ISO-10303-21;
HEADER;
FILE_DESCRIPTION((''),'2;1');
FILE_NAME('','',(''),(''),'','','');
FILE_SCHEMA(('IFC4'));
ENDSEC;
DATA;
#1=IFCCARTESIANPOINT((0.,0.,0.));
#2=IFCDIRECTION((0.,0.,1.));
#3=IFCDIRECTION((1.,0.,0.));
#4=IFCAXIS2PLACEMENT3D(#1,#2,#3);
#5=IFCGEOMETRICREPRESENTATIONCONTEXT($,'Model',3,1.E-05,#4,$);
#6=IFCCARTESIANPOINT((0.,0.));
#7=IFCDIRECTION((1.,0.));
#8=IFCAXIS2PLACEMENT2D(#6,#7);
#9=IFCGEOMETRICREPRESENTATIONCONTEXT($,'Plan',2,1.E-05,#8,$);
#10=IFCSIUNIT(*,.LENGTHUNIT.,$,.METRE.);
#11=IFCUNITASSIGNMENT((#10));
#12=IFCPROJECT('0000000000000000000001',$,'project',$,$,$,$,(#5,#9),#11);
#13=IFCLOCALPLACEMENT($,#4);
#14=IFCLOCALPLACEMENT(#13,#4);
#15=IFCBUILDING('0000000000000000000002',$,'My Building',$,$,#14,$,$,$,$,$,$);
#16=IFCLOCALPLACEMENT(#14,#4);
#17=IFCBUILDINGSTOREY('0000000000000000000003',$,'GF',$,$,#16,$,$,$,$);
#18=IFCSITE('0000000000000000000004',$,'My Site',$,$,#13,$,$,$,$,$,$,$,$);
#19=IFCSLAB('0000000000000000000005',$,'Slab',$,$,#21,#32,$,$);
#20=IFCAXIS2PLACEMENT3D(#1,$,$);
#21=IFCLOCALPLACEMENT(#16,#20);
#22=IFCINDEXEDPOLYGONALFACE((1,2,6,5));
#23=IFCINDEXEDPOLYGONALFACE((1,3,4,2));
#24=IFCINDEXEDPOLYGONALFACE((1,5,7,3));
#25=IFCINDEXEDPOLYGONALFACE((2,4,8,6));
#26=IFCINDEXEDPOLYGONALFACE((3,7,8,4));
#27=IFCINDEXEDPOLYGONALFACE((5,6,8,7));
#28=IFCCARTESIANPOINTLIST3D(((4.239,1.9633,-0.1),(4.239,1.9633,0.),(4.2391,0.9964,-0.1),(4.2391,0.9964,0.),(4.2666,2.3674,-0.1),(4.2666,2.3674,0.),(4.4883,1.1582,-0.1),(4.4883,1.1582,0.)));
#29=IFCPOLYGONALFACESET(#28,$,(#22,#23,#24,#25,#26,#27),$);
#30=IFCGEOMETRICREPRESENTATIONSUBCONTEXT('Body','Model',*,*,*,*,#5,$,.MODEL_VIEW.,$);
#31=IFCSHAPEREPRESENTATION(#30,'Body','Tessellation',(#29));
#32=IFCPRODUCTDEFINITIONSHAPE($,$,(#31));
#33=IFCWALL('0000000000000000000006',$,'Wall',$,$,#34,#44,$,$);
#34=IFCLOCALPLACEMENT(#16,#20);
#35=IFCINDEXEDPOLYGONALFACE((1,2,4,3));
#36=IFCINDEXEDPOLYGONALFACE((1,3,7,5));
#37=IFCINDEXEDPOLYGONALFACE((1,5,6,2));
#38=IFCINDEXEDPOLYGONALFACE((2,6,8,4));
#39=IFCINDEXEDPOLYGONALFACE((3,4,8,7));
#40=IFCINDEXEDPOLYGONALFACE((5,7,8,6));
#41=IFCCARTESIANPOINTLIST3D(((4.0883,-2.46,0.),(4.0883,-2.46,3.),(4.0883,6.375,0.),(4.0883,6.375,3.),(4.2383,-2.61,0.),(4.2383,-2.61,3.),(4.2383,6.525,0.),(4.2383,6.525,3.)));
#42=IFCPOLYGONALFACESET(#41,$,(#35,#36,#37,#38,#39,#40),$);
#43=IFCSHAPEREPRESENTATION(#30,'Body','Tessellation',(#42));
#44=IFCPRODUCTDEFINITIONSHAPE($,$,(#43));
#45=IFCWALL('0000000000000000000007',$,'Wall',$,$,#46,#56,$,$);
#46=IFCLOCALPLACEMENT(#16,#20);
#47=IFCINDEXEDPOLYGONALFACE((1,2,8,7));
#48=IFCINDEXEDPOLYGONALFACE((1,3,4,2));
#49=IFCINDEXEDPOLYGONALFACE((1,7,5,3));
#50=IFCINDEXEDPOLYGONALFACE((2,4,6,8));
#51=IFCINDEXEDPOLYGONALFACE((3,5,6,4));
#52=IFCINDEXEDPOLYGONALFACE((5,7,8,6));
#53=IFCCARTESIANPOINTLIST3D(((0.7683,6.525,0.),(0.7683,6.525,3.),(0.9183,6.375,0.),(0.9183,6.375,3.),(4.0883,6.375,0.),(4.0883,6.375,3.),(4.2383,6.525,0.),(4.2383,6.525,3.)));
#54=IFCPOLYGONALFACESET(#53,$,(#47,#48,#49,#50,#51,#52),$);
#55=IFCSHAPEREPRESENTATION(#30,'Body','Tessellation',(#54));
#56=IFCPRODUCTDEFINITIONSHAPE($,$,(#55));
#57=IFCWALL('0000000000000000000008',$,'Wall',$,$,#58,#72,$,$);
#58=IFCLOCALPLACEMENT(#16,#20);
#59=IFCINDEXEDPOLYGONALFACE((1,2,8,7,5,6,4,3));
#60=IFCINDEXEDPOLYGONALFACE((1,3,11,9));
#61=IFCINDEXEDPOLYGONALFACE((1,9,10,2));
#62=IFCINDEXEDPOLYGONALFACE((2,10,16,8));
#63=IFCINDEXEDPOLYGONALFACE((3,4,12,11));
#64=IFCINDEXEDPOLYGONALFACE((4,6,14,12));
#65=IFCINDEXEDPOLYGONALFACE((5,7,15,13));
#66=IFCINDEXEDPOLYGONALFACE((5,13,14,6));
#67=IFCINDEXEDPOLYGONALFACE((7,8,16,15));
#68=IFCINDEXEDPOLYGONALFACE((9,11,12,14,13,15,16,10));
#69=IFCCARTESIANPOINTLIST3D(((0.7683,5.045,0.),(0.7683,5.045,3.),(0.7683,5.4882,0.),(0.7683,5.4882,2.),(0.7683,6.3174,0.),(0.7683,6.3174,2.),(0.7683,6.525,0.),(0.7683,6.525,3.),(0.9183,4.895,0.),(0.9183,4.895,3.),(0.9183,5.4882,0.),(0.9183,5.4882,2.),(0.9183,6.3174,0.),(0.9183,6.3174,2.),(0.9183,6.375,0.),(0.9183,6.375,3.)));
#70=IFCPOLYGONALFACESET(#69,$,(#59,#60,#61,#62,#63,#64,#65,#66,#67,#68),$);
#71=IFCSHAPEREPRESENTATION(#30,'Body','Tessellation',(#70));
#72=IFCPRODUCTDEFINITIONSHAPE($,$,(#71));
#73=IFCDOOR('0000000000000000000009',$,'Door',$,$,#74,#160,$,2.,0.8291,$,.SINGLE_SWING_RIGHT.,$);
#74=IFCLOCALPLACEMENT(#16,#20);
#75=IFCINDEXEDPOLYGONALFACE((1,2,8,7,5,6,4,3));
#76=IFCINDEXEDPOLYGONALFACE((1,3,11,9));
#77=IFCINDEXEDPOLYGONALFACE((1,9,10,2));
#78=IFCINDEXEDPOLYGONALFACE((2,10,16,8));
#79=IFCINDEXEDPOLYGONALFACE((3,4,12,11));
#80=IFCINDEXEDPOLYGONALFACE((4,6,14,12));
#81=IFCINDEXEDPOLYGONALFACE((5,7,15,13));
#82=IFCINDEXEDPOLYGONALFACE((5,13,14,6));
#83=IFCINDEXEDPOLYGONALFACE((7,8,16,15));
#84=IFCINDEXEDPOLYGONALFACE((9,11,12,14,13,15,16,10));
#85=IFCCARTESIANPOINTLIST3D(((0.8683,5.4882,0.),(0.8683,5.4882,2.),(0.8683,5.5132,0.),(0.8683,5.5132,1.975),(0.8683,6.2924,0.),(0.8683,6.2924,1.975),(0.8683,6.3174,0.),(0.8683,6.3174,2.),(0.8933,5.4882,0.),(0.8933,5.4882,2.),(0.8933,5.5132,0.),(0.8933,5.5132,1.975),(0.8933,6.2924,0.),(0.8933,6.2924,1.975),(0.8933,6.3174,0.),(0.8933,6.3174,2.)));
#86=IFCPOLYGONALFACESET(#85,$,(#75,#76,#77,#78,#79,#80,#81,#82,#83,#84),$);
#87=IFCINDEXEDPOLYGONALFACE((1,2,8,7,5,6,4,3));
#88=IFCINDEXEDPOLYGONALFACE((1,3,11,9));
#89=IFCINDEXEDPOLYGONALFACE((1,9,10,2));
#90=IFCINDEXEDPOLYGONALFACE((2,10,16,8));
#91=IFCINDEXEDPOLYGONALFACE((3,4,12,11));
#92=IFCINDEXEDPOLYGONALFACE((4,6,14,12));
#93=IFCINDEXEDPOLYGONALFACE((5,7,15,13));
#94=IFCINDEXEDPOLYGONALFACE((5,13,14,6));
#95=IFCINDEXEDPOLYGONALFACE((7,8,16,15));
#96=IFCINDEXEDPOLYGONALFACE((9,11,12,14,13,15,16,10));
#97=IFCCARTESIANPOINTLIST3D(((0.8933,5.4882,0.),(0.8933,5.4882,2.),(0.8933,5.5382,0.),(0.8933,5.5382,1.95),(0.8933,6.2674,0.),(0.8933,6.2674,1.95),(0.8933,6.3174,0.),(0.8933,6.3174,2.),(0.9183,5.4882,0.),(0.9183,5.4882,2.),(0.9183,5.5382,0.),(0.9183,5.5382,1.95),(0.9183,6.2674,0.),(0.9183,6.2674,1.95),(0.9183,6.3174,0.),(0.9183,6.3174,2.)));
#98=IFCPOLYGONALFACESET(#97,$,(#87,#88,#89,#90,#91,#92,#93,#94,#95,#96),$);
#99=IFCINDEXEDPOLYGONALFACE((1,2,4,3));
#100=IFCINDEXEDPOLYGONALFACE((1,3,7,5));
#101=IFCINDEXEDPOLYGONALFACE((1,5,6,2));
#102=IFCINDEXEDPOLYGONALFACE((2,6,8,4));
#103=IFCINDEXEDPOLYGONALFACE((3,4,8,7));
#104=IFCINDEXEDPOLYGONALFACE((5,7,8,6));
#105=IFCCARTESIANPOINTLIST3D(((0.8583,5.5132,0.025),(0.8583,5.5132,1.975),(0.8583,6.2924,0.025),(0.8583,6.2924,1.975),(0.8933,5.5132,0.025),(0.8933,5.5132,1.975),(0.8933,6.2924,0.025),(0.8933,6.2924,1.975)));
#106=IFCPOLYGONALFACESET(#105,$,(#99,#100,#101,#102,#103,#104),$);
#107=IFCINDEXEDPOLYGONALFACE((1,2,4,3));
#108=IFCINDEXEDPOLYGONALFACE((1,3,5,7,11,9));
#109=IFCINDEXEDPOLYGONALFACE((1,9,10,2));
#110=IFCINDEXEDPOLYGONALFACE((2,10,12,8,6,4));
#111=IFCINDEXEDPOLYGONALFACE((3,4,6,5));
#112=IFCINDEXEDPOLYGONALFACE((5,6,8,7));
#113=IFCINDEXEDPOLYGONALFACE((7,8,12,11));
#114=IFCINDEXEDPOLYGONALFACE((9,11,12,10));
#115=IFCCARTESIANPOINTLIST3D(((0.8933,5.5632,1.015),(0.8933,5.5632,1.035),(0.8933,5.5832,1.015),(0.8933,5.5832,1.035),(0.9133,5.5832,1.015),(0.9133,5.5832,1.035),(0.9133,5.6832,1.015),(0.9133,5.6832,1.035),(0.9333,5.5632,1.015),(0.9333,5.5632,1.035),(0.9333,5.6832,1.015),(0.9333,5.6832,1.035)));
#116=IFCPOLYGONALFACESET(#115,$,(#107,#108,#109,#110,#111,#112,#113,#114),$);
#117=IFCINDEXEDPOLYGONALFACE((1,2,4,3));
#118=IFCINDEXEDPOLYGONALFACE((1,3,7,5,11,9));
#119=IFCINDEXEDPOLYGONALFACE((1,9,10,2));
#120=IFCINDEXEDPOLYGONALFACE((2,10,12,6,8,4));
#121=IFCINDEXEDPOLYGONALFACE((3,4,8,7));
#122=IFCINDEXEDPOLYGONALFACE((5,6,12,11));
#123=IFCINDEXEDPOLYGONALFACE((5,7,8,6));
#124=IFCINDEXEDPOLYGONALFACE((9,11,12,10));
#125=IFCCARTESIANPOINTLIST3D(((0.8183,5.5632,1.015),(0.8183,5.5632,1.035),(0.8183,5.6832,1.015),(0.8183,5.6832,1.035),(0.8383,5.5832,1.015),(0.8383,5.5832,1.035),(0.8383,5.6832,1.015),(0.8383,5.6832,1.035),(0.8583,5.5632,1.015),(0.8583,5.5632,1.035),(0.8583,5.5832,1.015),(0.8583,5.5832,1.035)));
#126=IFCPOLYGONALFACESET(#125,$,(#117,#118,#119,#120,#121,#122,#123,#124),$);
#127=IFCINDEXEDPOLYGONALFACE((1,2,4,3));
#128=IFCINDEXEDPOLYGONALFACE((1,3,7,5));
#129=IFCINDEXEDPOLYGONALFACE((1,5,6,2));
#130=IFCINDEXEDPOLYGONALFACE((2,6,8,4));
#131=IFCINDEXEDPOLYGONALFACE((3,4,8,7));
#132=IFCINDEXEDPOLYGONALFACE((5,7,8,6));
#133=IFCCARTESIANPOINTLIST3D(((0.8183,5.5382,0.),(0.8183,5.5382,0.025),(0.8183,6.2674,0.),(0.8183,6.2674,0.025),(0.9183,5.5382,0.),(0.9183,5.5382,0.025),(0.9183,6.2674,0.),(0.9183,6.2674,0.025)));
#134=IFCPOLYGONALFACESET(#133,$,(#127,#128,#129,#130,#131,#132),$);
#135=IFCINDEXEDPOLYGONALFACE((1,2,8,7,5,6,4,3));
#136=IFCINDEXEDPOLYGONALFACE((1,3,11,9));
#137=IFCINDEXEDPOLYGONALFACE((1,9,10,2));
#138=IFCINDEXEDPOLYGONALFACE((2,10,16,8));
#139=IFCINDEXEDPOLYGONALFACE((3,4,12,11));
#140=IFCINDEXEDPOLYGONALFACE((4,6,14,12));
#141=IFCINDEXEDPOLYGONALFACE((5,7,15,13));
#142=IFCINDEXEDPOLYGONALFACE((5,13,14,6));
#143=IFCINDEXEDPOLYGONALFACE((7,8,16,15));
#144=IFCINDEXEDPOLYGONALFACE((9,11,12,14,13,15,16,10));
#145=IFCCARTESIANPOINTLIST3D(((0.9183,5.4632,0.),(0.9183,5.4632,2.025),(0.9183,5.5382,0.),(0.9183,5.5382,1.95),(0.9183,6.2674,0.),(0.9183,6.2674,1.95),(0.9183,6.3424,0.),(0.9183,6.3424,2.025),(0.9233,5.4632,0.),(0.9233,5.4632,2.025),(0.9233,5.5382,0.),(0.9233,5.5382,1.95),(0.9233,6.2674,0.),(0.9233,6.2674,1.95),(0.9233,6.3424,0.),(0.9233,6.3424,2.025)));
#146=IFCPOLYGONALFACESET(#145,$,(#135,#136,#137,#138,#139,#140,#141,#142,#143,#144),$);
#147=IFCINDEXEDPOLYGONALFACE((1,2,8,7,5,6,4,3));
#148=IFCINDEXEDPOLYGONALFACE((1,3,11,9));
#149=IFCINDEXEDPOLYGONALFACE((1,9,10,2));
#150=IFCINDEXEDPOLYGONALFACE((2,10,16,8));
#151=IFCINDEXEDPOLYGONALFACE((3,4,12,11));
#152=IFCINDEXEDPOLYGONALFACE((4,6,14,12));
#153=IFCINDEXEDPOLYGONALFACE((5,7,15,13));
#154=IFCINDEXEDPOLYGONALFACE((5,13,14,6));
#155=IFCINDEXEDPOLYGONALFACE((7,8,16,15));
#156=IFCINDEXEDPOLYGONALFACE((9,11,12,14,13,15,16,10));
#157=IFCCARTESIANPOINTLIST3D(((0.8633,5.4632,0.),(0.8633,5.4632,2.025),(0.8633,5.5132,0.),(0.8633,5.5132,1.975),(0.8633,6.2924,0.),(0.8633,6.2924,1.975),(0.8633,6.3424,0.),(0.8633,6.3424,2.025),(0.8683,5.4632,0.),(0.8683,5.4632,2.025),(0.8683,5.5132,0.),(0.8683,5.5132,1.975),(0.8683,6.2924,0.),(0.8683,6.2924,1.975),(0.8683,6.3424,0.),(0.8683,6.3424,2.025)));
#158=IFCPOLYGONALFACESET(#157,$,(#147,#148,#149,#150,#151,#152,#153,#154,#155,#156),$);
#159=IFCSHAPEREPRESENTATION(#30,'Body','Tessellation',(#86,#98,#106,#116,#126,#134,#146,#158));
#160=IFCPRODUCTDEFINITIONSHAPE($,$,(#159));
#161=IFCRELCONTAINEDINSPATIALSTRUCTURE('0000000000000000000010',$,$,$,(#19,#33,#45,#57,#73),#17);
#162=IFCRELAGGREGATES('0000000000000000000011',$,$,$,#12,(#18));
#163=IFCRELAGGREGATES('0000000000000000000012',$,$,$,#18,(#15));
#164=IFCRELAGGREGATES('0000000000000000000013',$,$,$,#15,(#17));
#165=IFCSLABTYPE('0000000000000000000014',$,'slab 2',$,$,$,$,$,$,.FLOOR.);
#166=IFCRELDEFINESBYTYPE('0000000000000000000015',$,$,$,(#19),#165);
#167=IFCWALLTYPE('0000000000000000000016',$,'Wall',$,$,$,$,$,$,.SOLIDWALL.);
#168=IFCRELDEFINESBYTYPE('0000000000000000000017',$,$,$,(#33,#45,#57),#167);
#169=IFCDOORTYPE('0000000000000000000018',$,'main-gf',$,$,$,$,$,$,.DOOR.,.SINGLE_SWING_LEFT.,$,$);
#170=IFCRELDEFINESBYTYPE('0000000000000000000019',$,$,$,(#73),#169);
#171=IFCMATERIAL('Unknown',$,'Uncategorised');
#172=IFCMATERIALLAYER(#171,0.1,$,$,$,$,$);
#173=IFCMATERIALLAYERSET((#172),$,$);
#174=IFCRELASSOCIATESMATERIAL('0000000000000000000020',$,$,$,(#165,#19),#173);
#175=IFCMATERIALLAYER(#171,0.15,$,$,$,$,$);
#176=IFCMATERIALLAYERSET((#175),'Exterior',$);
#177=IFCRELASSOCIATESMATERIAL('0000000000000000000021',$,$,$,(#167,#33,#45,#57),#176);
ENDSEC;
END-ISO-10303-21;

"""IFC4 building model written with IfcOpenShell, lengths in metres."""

from ifc_helpers import new_model, entity, si_unit, frame, origin_with_axes, origin_2d_with_axis, place, context, subcontext, project, spatial, line, indexed_curve, outline, extrude, shape, source, transform, mapped, material, layer, layer_set, layer_usage, type_object, type_shapes, element, fill, save


model = new_model("IFC4")

# Units and contexts
model_context = context("Model", 3, precision=1e-05, world=origin_with_axes())
plan_context = context("Plan", 2, precision=1e-05, world=origin_2d_with_axis())
body_context_1 = subcontext(model_context, "Body", "Model", "MODEL_VIEW")
body_context_2 = subcontext(plan_context, "Body", "Plan", "PLAN_VIEW")
ifc_project = project(units=[si_unit("LENGTHUNIT", "METRE")], contexts=[model_context, plan_context])

# Site, building, storey
site_placement = place(None, origin_with_axes())
site = spatial("IfcSite", under=ifc_project, at=site_placement, Name="My Site")
building_placement = place(site_placement, origin_with_axes())
building = spatial("IfcBuilding", under=site, at=building_placement, Name="My Building")
storey_placement = place(building_placement, origin_with_axes())
storey = spatial("IfcBuildingStorey", under=building, at=storey_placement, Name="GF")

# Slab
ifc_material = material(Name="Unknown", Category="Uncategorised")
ifc_layer_1 = layer(ifc_material, 0.1)
ifc_layer_set_1 = layer_set([ifc_layer_1])
ifc_layer_usage_1 = layer_usage(ifc_layer_set_1, "AXIS3", "POSITIVE", -0.1)
slab_type_1 = type_object("IfcSlabType", Name="slab 2", PredefinedType="FLOOR", material=ifc_layer_set_1)
slab_1_placement = place(storey_placement, frame((4.2666, 2.3674, 0.0), z_axis=(0.0, 0.0, 1.0), x_axis=(1.0, 0.0, 0.0)))
element("IfcSlab", 1, at=slab_1_placement, inside=storey, type_object=slab_type_1, material=ifc_layer_usage_1, Name="Slab", context=body_context_1, shape_type="SweptSolid", body=[
    extrude(outline(indexed_curve([(0.0, 0.0), (0.2217, -1.2092), (-0.0275, -1.371), (-0.0276, -0.4041), (0.0, 0.0)])), frame((0.0, 0.0, -0.1), z_axis=(0.0, 0.0, 1.0), x_axis=(1.0, 0.0, 0.0)), (0.0, 0.0, 1.0), 0.1),
])

# Shared definitions
ifc_layer_2 = layer(ifc_material, 0.15)
ifc_layer_set_2 = layer_set([ifc_layer_2], Name="Exterior")
wall_type_1 = type_object("IfcWallType", Name="Wall", PredefinedType="SOLIDWALL", material=ifc_layer_set_2)
shared_shape_1 = source(origin_with_axes(), body_context_1, "Body", "SweptSolid", [
    extrude(outline(indexed_curve([(0.0, 0.0), (0.8291, 0.0), (0.8291, 2.0), (0.0, 2.0)], segments=[line(1, 2, 3, 4, 1)])), frame((0.0, -0.6, 0.0), z_axis=(0.0, -1.0, 0.0), x_axis=(1.0, 0.0, 0.0)), (0.0, 0.0, -1.0), 1.2),
])
door_type_1 = type_object("IfcDoorType", Name="main-gf", OperationType="SINGLE_SWING_LEFT", PredefinedType="DOOR")
shared_shape_2 = source(origin_with_axes(), body_context_1, "Body", "SweptSolid", [
    extrude(outline(indexed_curve([(0.0, 0.0), (0.0, 2.0), (0.8291, 2.0), (0.8291, 0.0), (0.8041, 0.0), (0.8041, 1.975), (0.025, 1.975), (0.025, 0.0)], segments=[line(1, 2, 3, 4, 5, 6, 7, 8, 1)])), frame((0.0, 0.025, 0.0), z_axis=(0.0, -1.0, 0.0), x_axis=(1.0, 0.0, 0.0)), (0.0, 0.0, -1.0), 0.025),
    extrude(outline(indexed_curve([(0.0, 0.0), (0.0, 2.0), (0.8291, 2.0), (0.8291, 0.0), (0.7791, 0.0), (0.7791, 1.95), (0.05, 1.95), (0.05, 0.0)], segments=[line(1, 2, 3, 4, 5, 6, 7, 8, 1)])), frame((0.0, 0.0, 0.0), z_axis=(0.0, -1.0, 0.0), x_axis=(1.0, 0.0, 0.0)), (0.0, 0.0, -1.0), 0.025),
    extrude(outline(indexed_curve([(0.0, 0.0), (0.7791, 0.0), (0.7791, 0.035), (0.0, 0.035)], segments=[line(1, 2, 3, 4, 1)])), frame((0.025, 0.025, 0.025), z_axis=(0.0, 0.0, 1.0), x_axis=(1.0, 0.0, 0.0)), (0.0, 0.0, 1.0), 1.95),
    extrude(outline(indexed_curve([(0.0, 0.0), (0.0, -0.04), (0.12, -0.04), (0.12, -0.02), (0.02, -0.02), (0.02, 0.0)], segments=[line(1, 2, 3, 4, 5, 6, 1)])), frame((0.075, 0.025, 1.015), z_axis=(0.0, 0.0, 1.0), x_axis=(1.0, 0.0, 0.0)), (0.0, 0.0, 1.0), 0.02),
    extrude(outline(indexed_curve([(0.0, 0.0), (0.0, 0.04), (0.12, 0.04), (0.12, 0.02), (0.02, 0.02), (0.02, 0.0)], segments=[line(1, 2, 3, 4, 5, 6, 1)])), frame((0.075, 0.06, 1.015), z_axis=(0.0, 0.0, 1.0), x_axis=(1.0, 0.0, 0.0)), (0.0, 0.0, 1.0), 0.02),
    extrude(outline(indexed_curve([(0.0, 0.0), (0.7291, 0.0), (0.7291, 0.1), (0.0, 0.1)], segments=[line(1, 2, 3, 4, 1)])), frame((0.05, 0.0, 0.0), z_axis=(0.0, 0.0, 1.0), x_axis=(1.0, 0.0, 0.0)), (0.0, 0.0, 1.0), 0.025),
    extrude(outline(indexed_curve([(0.0, 0.0), (0.0, 2.025), (0.8791, 2.025), (0.8791, 0.0), (0.8041, 0.0), (0.8041, 1.95), (0.075, 1.95), (0.075, 0.0)], segments=[line(1, 2, 3, 4, 5, 6, 7, 8, 1)])), frame((-0.025, -0.005, 0.0), z_axis=(0.0, -1.0, 0.0), x_axis=(1.0, 0.0, 0.0)), (0.0, 0.0, -1.0), 0.005),
    extrude(outline(indexed_curve([(0.0, 0.0), (0.0, 2.025), (0.8791, 2.025), (0.8791, 0.0), (0.8291, 0.0), (0.8291, 1.975), (0.05, 1.975), (0.05, 0.0)], segments=[line(1, 2, 3, 4, 5, 6, 7, 8, 1)])), frame((-0.025, 0.05, 0.0), z_axis=(0.0, -1.0, 0.0), x_axis=(1.0, 0.0, 0.0)), (0.0, 0.0, -1.0), 0.005),
])
shared_shape_3 = source(origin_with_axes(), body_context_2, "Body", "Curve2D", [
    entity("IfcIndexedPolyCurve", entity("IfcCartesianPointList2D", [[0.0, 0.0], [0.0, 0.05], [0.025, 0.05], [0.025, 0.025], [0.05, 0.025], [0.05, 0.0]]), [entity("IfcLineIndex", [1, 2, 3, 4, 5, 6, 1])]),
    entity("IfcIndexedPolyCurve", entity("IfcCartesianPointList2D", [[0.8291, 0.0], [0.8291, 0.05], [0.8041, 0.05], [0.8041, 0.025], [0.7791, 0.025], [0.7791, 0.0]]), [entity("IfcLineIndex", [1, 2, 3, 4, 5, 6, 1])]),
    entity("IfcTrimmedCurve", entity("IfcEllipse", entity("IfcAxis2Placement2D", entity("IfcCartesianPoint", [0.7691, 0.05]), entity("IfcDirection", [1.0, 0.0])), 0.7441, 0.7791), [entity("IfcCartesianPoint", [0.7691, 0.8291])], [entity("IfcCartesianPoint", [0.025, 0.05])], True, "CARTESIAN"),
    entity("IfcIndexedPolyCurve", entity("IfcCartesianPointList2D", [[0.8041, 0.05], [0.7691, 0.05], [0.7691, 0.8291], [0.8041, 0.8291]]), [entity("IfcLineIndex", [1, 2, 3, 4, 1])]),
])
type_shapes(door_type_1, [shared_shape_2, shared_shape_3])

# Walls
ifc_layer_usage_2 = layer_usage(ifc_layer_set_2, "AXIS2", "POSITIVE", 0.0)
wall_1_placement = place(storey_placement, frame((4.2383, -2.61, 0.0), z_axis=(0.0, 0.0, 1.0), x_axis=(0.0, 1.0, 0.0)))
element("IfcWall", 2, at=wall_1_placement, inside=storey, type_object=wall_type_1, material=ifc_layer_usage_2, Name="Wall", context=body_context_1, shape_type="SweptSolid", body=[
    extrude(outline(indexed_curve([(0.0, 0.0), (0.15, 0.15), (8.985, 0.15), (9.135, 0.0)], segments=[line(1, 2, 3, 4, 1)])), origin_with_axes(), (0.0, 0.0, 1.0), 3.0),
])
ifc_layer_usage_3 = layer_usage(ifc_layer_set_2, "AXIS2", "POSITIVE", 0.0)
wall_2_placement = place(storey_placement, frame((4.2383, 6.525, 0.0), z_axis=(0.0, 0.0, 1.0), x_axis=(-1.0, 0.0, 0.0)))
element("IfcWall", 3, at=wall_2_placement, inside=storey, type_object=wall_type_1, material=ifc_layer_usage_3, Name="Wall", context=body_context_1, shape_type="SweptSolid", body=[
    extrude(outline(indexed_curve([(0.0, 0.0), (0.15, 0.15), (3.32, 0.15), (3.47, 0.0)], segments=[line(1, 2, 3, 4, 1)])), origin_with_axes(), (0.0, 0.0, 1.0), 3.0),
])

# Wall, opening, door
ifc_layer_usage_4 = layer_usage(ifc_layer_set_2, "AXIS2", "POSITIVE", 0.0)
wall_3_placement = place(storey_placement, frame((0.7683, 6.525, 0.0), z_axis=(0.0, 0.0, 1.0), x_axis=(0.0, -1.0, 0.0)))
wall_3 = element("IfcWall", 4, at=wall_3_placement, inside=storey, type_object=wall_type_1, material=ifc_layer_usage_4, Name="Wall", context=body_context_1, shape_type="SweptSolid", body=[
    extrude(outline(indexed_curve([(0.0, 0.0), (0.15, 0.15), (1.63, 0.15), (1.48, 0.0)], segments=[line(1, 2, 3, 4, 1)])), origin_with_axes(), (0.0, 0.0, 1.0), 3.0),
])
opening_1_placement = place(wall_3_placement, frame((1.0368, 0.15, 0.0), z_axis=(0.0, 0.0, 1.0), x_axis=(-1.0, 0.0, 0.0)))
opening_1 = element("IfcOpeningElement", 5, at=opening_1_placement, cuts=wall_3, PredefinedType="OPENING", context=body_context_1, shape_type="MappedRepresentation", body=[
    mapped(shared_shape_1, transform((0.0, 0.0, 0.0), x_axis=(1.0, 0.0, 0.0), y_axis=(0.0, 1.0, 0.0), z_axis=(0.0, 0.0, 1.0), scale=1.0)),
])
door_1_placement = place(opening_1_placement, frame((0.0, 0.0, 0.0), z_axis=(0.0, 0.0, 1.0), x_axis=(1.0, 0.0, 0.0)))
door_1 = element("IfcDoor", 6, at=door_1_placement, inside=storey, type_object=door_type_1, Name="Door", OperationType="SINGLE_SWING_RIGHT", OverallHeight=2.0, OverallWidth=0.8291, shapes=[
    shape(body_context_1, "Body", "MappedRepresentation", [mapped(shared_shape_2, transform((0.0, 0.0, 0.0), x_axis=(1.0, 0.0, 0.0), y_axis=(0.0, 1.0, 0.0), z_axis=(0.0, 0.0, 1.0), scale=1.0))]),
    shape(body_context_2, "Body", "MappedRepresentation", [mapped(shared_shape_3, transform((0.0, 0.0, 0.0), x_axis=(1.0, 0.0, 0.0), y_axis=(0.0, 1.0, 0.0), z_axis=(0.0, 0.0, 1.0), scale=1.0))]),
])
fill(opening_1, door_1)

save(model, "model.ifc")
